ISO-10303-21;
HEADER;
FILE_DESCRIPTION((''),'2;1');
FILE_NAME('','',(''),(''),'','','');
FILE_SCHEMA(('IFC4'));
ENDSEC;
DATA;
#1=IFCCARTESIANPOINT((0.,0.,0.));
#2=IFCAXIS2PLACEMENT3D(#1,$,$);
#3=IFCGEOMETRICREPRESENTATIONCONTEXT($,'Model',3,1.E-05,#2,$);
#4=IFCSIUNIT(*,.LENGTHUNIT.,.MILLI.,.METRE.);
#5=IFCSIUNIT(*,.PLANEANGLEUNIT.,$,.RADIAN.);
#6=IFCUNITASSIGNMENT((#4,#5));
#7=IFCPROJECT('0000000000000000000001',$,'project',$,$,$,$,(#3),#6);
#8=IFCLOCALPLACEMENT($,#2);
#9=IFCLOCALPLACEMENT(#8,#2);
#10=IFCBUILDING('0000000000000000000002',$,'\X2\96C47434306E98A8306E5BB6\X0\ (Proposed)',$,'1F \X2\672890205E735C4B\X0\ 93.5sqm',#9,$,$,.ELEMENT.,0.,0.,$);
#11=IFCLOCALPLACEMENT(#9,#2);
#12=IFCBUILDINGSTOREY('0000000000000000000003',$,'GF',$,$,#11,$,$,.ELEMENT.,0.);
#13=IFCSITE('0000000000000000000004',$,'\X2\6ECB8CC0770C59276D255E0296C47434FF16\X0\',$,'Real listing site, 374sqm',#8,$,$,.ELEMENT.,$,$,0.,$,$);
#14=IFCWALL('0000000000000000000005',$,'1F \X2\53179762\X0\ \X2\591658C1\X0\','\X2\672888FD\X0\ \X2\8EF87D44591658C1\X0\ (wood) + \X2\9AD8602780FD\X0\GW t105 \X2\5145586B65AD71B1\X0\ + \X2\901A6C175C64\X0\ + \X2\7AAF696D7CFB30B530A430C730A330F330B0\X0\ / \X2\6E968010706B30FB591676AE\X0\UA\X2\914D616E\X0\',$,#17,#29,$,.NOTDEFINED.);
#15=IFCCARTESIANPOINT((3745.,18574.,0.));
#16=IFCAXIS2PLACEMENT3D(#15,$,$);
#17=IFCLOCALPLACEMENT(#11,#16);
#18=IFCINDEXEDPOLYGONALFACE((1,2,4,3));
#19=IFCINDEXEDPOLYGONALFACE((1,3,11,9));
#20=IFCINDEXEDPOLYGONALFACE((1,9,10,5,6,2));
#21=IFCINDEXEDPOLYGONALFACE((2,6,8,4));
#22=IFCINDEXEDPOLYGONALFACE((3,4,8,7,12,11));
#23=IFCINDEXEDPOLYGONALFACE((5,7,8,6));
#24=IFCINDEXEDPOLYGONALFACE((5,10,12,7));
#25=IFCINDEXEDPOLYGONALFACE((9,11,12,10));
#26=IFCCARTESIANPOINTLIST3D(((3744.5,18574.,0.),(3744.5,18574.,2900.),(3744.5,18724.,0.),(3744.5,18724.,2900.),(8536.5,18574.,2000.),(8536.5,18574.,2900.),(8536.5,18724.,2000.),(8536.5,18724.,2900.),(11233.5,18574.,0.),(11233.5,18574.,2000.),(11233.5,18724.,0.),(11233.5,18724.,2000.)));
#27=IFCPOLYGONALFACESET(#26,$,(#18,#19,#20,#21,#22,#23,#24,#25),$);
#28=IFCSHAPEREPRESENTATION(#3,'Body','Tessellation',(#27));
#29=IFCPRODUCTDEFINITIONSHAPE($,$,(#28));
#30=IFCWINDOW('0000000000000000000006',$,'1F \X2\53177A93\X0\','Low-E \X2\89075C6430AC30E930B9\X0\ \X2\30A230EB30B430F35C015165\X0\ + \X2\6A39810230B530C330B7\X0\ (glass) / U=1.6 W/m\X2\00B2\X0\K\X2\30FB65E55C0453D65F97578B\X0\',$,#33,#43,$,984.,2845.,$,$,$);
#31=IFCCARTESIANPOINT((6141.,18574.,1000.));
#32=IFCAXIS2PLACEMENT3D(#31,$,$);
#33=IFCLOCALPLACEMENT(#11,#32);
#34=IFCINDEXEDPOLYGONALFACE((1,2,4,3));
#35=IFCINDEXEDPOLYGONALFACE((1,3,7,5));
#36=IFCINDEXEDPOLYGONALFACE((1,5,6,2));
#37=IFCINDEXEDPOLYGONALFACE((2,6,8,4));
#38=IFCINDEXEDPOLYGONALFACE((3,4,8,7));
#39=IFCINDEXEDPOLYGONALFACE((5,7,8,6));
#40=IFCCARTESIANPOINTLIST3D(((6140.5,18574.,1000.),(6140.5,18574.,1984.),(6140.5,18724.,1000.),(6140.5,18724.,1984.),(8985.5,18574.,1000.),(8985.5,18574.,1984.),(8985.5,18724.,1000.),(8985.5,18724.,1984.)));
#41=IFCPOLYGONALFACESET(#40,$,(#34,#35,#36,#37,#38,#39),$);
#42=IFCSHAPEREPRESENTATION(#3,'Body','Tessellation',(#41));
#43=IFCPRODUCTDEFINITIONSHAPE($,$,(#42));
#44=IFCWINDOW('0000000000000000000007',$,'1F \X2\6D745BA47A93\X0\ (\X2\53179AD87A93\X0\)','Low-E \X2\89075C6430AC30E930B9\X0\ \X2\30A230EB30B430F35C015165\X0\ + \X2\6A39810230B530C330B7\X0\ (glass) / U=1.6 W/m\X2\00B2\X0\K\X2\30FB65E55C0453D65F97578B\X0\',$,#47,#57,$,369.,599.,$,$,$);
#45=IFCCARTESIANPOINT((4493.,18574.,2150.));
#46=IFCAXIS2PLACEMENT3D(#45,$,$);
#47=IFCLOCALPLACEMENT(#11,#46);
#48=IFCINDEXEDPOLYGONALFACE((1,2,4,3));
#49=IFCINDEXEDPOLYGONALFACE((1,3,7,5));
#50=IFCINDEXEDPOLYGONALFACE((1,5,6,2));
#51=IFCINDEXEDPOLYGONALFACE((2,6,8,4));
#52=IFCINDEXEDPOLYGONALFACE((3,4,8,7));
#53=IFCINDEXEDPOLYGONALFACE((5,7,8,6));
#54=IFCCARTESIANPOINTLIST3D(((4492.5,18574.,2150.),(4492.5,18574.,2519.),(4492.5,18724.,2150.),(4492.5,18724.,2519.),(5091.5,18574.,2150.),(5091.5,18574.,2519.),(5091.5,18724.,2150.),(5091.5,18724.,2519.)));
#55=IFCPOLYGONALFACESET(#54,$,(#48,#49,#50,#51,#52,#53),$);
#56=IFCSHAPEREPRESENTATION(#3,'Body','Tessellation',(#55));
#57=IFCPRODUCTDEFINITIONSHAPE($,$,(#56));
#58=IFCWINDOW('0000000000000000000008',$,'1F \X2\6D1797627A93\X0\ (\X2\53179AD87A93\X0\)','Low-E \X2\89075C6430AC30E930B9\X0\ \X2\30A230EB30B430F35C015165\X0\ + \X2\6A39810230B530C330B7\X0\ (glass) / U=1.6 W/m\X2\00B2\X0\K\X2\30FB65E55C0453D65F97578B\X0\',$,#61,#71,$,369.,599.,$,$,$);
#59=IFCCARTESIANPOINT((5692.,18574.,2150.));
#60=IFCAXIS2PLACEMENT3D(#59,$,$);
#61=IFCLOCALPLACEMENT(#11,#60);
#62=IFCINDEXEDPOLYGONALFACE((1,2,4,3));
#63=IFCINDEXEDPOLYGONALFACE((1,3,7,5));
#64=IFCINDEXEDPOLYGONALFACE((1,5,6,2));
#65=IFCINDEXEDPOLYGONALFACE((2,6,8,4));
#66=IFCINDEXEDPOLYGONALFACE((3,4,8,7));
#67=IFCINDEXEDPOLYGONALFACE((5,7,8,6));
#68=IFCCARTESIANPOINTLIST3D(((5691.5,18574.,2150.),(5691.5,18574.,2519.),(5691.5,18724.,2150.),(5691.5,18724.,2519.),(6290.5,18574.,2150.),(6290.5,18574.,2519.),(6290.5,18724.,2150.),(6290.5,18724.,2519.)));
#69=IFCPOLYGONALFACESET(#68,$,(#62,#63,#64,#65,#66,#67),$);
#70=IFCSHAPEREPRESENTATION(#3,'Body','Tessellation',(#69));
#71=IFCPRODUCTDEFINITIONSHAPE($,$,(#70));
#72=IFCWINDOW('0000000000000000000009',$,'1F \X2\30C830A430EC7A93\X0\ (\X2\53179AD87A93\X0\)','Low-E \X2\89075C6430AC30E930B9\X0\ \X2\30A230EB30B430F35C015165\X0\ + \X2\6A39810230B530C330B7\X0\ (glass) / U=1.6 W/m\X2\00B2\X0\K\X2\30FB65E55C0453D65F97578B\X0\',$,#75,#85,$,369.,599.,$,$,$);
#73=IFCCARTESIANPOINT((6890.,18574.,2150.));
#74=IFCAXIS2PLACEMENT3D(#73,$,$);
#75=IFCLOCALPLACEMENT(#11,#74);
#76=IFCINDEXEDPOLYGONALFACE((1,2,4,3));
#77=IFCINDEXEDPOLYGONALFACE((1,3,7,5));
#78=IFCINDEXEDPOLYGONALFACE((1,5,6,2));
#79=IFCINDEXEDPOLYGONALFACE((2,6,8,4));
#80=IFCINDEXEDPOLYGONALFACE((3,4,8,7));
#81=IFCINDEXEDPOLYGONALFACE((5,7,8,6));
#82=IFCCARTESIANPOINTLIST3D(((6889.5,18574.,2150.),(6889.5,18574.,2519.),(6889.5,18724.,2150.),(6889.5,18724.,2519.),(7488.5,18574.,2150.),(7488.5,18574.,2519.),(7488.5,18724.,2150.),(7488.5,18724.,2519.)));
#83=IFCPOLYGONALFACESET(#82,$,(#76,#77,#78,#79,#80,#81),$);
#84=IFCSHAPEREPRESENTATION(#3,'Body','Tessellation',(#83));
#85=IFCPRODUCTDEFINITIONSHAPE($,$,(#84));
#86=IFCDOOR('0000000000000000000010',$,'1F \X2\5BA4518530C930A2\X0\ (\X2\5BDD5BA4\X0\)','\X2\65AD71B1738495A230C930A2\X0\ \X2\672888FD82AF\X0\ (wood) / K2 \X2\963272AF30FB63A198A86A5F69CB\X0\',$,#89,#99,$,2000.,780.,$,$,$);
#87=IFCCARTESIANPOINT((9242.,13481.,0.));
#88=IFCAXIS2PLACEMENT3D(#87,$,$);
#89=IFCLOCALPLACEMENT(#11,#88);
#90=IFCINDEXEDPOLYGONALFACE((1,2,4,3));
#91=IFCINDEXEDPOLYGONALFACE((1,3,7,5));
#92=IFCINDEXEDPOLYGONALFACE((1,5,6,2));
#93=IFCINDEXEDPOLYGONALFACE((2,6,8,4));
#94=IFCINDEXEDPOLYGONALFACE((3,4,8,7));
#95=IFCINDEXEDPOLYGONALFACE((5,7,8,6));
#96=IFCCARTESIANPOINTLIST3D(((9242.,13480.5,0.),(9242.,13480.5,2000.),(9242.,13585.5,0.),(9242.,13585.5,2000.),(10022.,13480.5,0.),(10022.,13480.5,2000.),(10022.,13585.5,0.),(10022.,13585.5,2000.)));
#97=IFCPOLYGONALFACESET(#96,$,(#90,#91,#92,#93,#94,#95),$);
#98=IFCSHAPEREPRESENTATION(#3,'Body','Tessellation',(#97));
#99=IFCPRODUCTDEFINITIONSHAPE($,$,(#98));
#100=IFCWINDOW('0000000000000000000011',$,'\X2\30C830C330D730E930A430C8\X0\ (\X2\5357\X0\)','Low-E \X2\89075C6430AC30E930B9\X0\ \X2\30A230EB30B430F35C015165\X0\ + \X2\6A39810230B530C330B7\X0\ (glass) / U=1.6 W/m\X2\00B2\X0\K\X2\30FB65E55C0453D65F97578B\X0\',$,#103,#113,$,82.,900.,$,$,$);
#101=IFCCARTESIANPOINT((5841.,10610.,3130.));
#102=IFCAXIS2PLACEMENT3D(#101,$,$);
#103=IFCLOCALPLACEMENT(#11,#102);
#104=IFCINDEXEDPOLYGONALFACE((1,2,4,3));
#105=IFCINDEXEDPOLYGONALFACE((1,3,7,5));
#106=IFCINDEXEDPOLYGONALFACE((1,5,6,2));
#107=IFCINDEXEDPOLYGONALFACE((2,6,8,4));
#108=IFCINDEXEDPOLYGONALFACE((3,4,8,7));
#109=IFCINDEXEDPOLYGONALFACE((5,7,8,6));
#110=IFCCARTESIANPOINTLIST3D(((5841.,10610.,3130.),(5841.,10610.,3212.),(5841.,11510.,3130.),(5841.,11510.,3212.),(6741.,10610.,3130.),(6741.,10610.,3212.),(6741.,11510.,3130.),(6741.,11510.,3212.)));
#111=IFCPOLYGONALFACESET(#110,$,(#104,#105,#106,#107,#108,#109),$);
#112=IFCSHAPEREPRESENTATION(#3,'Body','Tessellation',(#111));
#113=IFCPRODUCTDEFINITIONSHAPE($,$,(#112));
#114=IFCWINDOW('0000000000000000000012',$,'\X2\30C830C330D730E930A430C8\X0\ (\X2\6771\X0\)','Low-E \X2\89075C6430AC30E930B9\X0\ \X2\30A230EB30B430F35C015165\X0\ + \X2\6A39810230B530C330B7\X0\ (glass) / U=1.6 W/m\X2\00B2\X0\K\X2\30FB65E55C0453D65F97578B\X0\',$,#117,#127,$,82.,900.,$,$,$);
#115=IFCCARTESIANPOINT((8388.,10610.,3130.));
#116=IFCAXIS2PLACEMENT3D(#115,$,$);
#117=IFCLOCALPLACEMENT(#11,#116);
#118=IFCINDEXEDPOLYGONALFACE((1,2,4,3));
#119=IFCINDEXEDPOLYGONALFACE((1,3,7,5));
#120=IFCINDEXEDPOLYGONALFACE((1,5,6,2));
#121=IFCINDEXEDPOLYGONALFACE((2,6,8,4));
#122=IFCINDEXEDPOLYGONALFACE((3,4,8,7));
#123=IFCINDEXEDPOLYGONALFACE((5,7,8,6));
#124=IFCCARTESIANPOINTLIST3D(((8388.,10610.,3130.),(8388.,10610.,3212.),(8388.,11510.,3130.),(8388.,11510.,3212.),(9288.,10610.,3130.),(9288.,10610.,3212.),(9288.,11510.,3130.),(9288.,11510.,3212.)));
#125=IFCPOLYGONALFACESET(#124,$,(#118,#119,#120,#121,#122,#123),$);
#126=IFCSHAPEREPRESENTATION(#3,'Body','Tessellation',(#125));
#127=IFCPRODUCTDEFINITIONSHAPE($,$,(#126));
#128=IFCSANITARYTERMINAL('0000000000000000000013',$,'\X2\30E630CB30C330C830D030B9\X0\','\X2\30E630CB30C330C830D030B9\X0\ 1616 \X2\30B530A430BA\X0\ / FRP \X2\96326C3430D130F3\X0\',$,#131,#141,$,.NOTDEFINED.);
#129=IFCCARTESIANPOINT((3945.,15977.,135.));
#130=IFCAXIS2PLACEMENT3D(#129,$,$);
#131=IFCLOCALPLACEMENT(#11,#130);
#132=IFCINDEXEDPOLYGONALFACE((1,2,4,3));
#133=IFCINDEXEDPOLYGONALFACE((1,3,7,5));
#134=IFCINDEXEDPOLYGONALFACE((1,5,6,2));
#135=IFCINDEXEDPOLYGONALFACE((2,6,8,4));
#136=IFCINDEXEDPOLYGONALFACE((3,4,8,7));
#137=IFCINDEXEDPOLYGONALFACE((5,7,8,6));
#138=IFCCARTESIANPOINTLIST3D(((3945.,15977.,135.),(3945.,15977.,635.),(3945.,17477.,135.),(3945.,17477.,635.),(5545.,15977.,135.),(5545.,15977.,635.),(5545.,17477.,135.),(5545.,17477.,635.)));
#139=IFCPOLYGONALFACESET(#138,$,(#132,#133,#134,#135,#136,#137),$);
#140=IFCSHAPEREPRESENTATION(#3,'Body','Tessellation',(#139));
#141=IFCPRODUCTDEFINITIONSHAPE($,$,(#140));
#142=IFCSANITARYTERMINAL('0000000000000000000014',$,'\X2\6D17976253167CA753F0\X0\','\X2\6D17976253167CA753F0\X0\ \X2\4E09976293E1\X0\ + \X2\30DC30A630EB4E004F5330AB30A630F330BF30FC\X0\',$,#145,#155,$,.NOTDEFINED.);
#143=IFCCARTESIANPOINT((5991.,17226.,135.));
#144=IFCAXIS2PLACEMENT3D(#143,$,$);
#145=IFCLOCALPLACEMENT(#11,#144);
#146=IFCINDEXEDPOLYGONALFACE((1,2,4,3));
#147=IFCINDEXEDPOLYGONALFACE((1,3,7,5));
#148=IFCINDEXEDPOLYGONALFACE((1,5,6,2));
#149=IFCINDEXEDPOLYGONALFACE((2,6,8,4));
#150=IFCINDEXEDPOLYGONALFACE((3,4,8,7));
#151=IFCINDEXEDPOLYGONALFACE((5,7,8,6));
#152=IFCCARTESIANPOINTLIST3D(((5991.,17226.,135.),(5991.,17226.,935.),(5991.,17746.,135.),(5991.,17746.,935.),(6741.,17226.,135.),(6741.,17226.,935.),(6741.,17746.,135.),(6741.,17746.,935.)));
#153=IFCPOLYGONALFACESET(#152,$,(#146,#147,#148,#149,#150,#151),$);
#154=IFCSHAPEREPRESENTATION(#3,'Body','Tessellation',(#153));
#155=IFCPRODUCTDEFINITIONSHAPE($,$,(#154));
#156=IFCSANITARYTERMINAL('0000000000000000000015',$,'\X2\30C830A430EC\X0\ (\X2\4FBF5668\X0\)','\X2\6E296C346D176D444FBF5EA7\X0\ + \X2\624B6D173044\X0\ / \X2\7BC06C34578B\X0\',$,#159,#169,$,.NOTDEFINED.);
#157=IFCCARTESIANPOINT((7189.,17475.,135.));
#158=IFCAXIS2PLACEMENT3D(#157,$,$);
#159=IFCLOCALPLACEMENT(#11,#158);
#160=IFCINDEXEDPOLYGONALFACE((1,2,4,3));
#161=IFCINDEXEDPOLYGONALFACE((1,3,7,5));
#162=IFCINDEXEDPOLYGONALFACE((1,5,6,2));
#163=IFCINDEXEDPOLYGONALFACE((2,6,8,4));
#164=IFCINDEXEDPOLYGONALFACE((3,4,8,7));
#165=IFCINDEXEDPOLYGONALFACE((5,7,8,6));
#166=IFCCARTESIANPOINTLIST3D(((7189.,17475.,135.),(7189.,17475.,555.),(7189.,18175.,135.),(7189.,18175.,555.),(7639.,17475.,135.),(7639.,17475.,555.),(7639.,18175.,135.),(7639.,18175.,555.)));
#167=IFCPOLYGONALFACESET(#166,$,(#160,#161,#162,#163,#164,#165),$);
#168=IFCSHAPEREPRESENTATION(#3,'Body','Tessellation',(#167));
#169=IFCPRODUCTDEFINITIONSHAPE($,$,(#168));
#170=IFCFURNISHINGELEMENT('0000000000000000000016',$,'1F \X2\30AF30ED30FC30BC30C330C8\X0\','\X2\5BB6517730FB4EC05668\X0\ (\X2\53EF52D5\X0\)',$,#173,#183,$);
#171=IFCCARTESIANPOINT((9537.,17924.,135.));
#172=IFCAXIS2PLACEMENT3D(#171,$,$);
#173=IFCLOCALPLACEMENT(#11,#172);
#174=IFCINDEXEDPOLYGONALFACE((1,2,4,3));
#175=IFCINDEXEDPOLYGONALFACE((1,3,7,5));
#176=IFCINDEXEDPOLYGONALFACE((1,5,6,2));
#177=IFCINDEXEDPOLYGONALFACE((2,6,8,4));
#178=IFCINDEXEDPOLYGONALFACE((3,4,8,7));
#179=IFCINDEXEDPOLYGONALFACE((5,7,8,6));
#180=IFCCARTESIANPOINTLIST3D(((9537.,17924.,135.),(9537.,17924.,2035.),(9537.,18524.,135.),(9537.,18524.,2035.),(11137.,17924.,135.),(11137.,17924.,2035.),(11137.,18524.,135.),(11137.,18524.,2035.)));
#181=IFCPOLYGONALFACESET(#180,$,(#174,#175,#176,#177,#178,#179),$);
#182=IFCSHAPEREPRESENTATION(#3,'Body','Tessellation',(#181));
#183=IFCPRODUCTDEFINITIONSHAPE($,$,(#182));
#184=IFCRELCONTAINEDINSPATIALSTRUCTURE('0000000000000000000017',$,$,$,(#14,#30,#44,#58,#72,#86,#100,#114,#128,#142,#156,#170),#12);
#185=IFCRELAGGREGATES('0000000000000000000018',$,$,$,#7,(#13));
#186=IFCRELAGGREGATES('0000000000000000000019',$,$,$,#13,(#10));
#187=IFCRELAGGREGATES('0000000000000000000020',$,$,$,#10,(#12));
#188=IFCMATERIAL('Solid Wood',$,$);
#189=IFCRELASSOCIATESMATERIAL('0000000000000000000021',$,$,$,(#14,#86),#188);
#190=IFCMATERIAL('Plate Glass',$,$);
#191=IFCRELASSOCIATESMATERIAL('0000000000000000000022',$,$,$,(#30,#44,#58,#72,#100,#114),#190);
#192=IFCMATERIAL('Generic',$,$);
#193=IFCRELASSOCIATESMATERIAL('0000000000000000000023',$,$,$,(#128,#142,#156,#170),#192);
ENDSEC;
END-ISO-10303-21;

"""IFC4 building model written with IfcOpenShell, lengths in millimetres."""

from ifc_helpers import new_model, si_unit, frame, frame_2d, origin, place, context, project, spatial, rectangle, extrude, material, element, fill, save


model = new_model("IFC4")

# Units and contexts
model_context = context("Model", 3, precision=1e-05, world=origin())
ifc_project = project(units=[si_unit("LENGTHUNIT", "METRE", prefix="MILLI"), si_unit("PLANEANGLEUNIT", "RADIAN")], contexts=[model_context])

# Site, building, storey
site_placement = place(None, origin())
site = spatial("IfcSite", under=ifc_project, at=site_placement, Name="滋賀県大津市雄琴６", ObjectType="Real listing site, 374sqm", CompositionType="ELEMENT", RefElevation=0.0)
building_placement = place(site_placement, origin())
building = spatial("IfcBuilding", under=site, at=building_placement, Name="雄琴の風の家 (Proposed)", ObjectType="1F 木造平屋 93.5sqm", CompositionType="ELEMENT", ElevationOfRefHeight=0.0, ElevationOfTerrain=0.0)
storey_placement = place(building_placement, origin())
storey = spatial("IfcBuildingStorey", under=building, at=storey_placement, Name="GF", CompositionType="ELEMENT", Elevation=0.0)

# Shared definitions
ifc_material_1 = material(Name="Solid Wood")

# Wall, openings, windows
wall_1_placement = place(storey_placement, frame((3745.0, 18574.0, 0.0)))
wall_1 = element("IfcWall", 1, at=wall_1_placement, inside=storey, material=ifc_material_1, Name="1F 北面 外壁", Description="木製 軸組外壁 (wood) + 高性能GW t105 充填断熱 + 通気層 + 窯業系サイディング / 準耐火・外皮UA配慮", PredefinedType="NOTDEFINED", context=model_context, shape_type="SweptSolid", body=[
    extrude(rectangle(XDim=7489.0, YDim=150.0, at=frame_2d((3744.0, 75.0))), frame((3745.0, 18574.0, 0.0)), (0.0, 0.0, 1.0), 2900.0),
])
opening_1_placement = place(storey_placement, frame((6141.0, 18574.0, 1000.0)))
opening_1 = element("IfcOpeningElement", 2, at=opening_1_placement, cuts=wall_1, PredefinedType="NOTDEFINED", context=model_context, shape_type="SweptSolid", body=[
    extrude(rectangle(XDim=2845.0, YDim=150.0, at=frame_2d((1422.0, 75.0))), frame((6141.0, 18574.0, 1000.0)), (0.0, 0.0, 1.0), 984.0),
])
opening_2_placement = place(storey_placement, frame((4493.0, 18574.0, 2150.0)))
opening_2 = element("IfcOpeningElement", 3, at=opening_2_placement, cuts=wall_1, PredefinedType="NOTDEFINED", context=model_context, shape_type="SweptSolid", body=[
    extrude(rectangle(XDim=599.0, YDim=150.0, at=frame_2d((299.0, 75.0))), frame((4493.0, 18574.0, 2150.0)), (0.0, 0.0, 1.0), 369.0),
])
opening_3_placement = place(storey_placement, frame((5692.0, 18574.0, 2150.0)))
opening_3 = element("IfcOpeningElement", 4, at=opening_3_placement, cuts=wall_1, PredefinedType="NOTDEFINED", context=model_context, shape_type="SweptSolid", body=[
    extrude(rectangle(XDim=599.0, YDim=150.0, at=frame_2d((299.0, 75.0))), frame((5692.0, 18574.0, 2150.0)), (0.0, 0.0, 1.0), 369.0),
])
opening_4_placement = place(storey_placement, frame((6890.0, 18574.0, 2150.0)))
opening_4 = element("IfcOpeningElement", 5, at=opening_4_placement, cuts=wall_1, PredefinedType="NOTDEFINED", context=model_context, shape_type="SweptSolid", body=[
    extrude(rectangle(XDim=599.0, YDim=150.0, at=frame_2d((299.0, 75.0))), frame((6890.0, 18574.0, 2150.0)), (0.0, 0.0, 1.0), 369.0),
])
ifc_material_2 = material(Name="Plate Glass")
window_1_placement = place(storey_placement, frame((6141.0, 18574.0, 1000.0)))
window_1 = element("IfcWindow", 6, at=window_1_placement, inside=storey, material=ifc_material_2, Name="1F 北窓", Description="Low-E 複層ガラス アルゴン封入 + 樹脂サッシ (glass) / U=1.6 W/m²K・日射取得型", OverallHeight=984.0, OverallWidth=2845.0, context=model_context, shape_type="SweptSolid", body=[
    extrude(rectangle(XDim=2845.0, YDim=150.0, at=frame_2d((1422.0, 75.0))), frame((6141.0, 18574.0, 1000.0)), (0.0, 0.0, 1.0), 984.0),
])
fill(opening_1, window_1)
window_2_placement = place(storey_placement, frame((4493.0, 18574.0, 2150.0)))
window_2 = element("IfcWindow", 7, at=window_2_placement, inside=storey, material=ifc_material_2, Name="1F 浴室窓 (北高窓)", Description="Low-E 複層ガラス アルゴン封入 + 樹脂サッシ (glass) / U=1.6 W/m²K・日射取得型", OverallHeight=369.0, OverallWidth=599.0, context=model_context, shape_type="SweptSolid", body=[
    extrude(rectangle(XDim=599.0, YDim=150.0, at=frame_2d((299.0, 75.0))), frame((4493.0, 18574.0, 2150.0)), (0.0, 0.0, 1.0), 369.0),
])
fill(opening_2, window_2)
window_3_placement = place(storey_placement, frame((5692.0, 18574.0, 2150.0)))
window_3 = element("IfcWindow", 8, at=window_3_placement, inside=storey, material=ifc_material_2, Name="1F 洗面窓 (北高窓)", Description="Low-E 複層ガラス アルゴン封入 + 樹脂サッシ (glass) / U=1.6 W/m²K・日射取得型", OverallHeight=369.0, OverallWidth=599.0, context=model_context, shape_type="SweptSolid", body=[
    extrude(rectangle(XDim=599.0, YDim=150.0, at=frame_2d((299.0, 75.0))), frame((5692.0, 18574.0, 2150.0)), (0.0, 0.0, 1.0), 369.0),
])
fill(opening_3, window_3)
window_4_placement = place(storey_placement, frame((6890.0, 18574.0, 2150.0)))
window_4 = element("IfcWindow", 9, at=window_4_placement, inside=storey, material=ifc_material_2, Name="1F トイレ窓 (北高窓)", Description="Low-E 複層ガラス アルゴン封入 + 樹脂サッシ (glass) / U=1.6 W/m²K・日射取得型", OverallHeight=369.0, OverallWidth=599.0, context=model_context, shape_type="SweptSolid", body=[
    extrude(rectangle(XDim=599.0, YDim=150.0, at=frame_2d((299.0, 75.0))), frame((6890.0, 18574.0, 2150.0)), (0.0, 0.0, 1.0), 369.0),
])
fill(opening_4, window_4)

# Door
door_1_placement = place(storey_placement, frame((9242.0, 13481.0, 0.0)))
element("IfcDoor", 10, at=door_1_placement, inside=storey, material=ifc_material_1, Name="1F 室内ドア (寝室)", Description="断熱玄関ドア 木製芯 (wood) / K2 防犯・採風機構", OverallHeight=2000.0, OverallWidth=780.0, context=model_context, shape_type="SweptSolid", body=[
    extrude(rectangle(XDim=780.0, YDim=105.0, at=frame_2d((390.0, 52.0))), frame((9242.0, 13481.0, 0.0)), (0.0, 0.0, 1.0), 2000.0),
])

# Windows
window_5_placement = place(storey_placement, frame((5841.0, 10610.0, 3130.0)))
element("IfcWindow", 11, at=window_5_placement, inside=storey, material=ifc_material_2, Name="トップライト (南)", Description="Low-E 複層ガラス アルゴン封入 + 樹脂サッシ (glass) / U=1.6 W/m²K・日射取得型", OverallHeight=82.0, OverallWidth=900.0, context=model_context, shape_type="SweptSolid", body=[
    extrude(rectangle(XDim=900.0, YDim=900.0, at=frame_2d((450.0, 450.0))), frame((5841.0, 10610.0, 3130.0)), (0.0, 0.0, 1.0), 82.0),
])
window_6_placement = place(storey_placement, frame((8388.0, 10610.0, 3130.0)))
element("IfcWindow", 12, at=window_6_placement, inside=storey, material=ifc_material_2, Name="トップライト (東)", Description="Low-E 複層ガラス アルゴン封入 + 樹脂サッシ (glass) / U=1.6 W/m²K・日射取得型", OverallHeight=82.0, OverallWidth=900.0, context=model_context, shape_type="SweptSolid", body=[
    extrude(rectangle(XDim=900.0, YDim=900.0, at=frame_2d((450.0, 450.0))), frame((8388.0, 10610.0, 3130.0)), (0.0, 0.0, 1.0), 82.0),
])

# Sanitary terminals
ifc_material_3 = material(Name="Generic")
sanitary_terminal_1_placement = place(storey_placement, frame((3945.0, 15977.0, 135.0)))
element("IfcSanitaryTerminal", 13, at=sanitary_terminal_1_placement, inside=storey, material=ifc_material_3, Name="ユニットバス", Description="ユニットバス 1616 サイズ / FRP 防水パン", PredefinedType="NOTDEFINED", context=model_context, shape_type="SweptSolid", body=[
    extrude(rectangle(XDim=1600.0, YDim=1500.0, at=frame_2d((800.0, 750.0))), frame((3945.0, 15977.0, 135.0)), (0.0, 0.0, 1.0), 500.0),
])
sanitary_terminal_2_placement = place(storey_placement, frame((5991.0, 17226.0, 135.0)))
element("IfcSanitaryTerminal", 14, at=sanitary_terminal_2_placement, inside=storey, material=ifc_material_3, Name="洗面化粧台", Description="洗面化粧台 三面鏡 + ボウル一体カウンター", PredefinedType="NOTDEFINED", context=model_context, shape_type="SweptSolid", body=[
    extrude(rectangle(XDim=750.0, YDim=520.0, at=frame_2d((375.0, 260.0))), frame((5991.0, 17226.0, 135.0)), (0.0, 0.0, 1.0), 800.0),
])
sanitary_terminal_3_placement = place(storey_placement, frame((7189.0, 17475.0, 135.0)))
element("IfcSanitaryTerminal", 15, at=sanitary_terminal_3_placement, inside=storey, material=ifc_material_3, Name="トイレ (便器)", Description="温水洗浄便座 + 手洗い / 節水型", PredefinedType="NOTDEFINED", context=model_context, shape_type="SweptSolid", body=[
    extrude(rectangle(XDim=450.0, YDim=700.0, at=frame_2d((225.0, 350.0))), frame((7189.0, 17475.0, 135.0)), (0.0, 0.0, 1.0), 420.0),
])

# Furnishing element
furnishing_1_placement = place(storey_placement, frame((9537.0, 17924.0, 135.0)))
element("IfcFurnishingElement", 16, at=furnishing_1_placement, inside=storey, material=ifc_material_3, Name="1F クローゼット", Description="家具・什器 (可動)", context=model_context, shape_type="SweptSolid", body=[
    extrude(rectangle(XDim=1600.0, YDim=600.0, at=frame_2d((800.0, 300.0))), frame((9537.0, 17924.0, 135.0)), (0.0, 0.0, 1.0), 1900.0),
])

save(model, "model.ifc")
